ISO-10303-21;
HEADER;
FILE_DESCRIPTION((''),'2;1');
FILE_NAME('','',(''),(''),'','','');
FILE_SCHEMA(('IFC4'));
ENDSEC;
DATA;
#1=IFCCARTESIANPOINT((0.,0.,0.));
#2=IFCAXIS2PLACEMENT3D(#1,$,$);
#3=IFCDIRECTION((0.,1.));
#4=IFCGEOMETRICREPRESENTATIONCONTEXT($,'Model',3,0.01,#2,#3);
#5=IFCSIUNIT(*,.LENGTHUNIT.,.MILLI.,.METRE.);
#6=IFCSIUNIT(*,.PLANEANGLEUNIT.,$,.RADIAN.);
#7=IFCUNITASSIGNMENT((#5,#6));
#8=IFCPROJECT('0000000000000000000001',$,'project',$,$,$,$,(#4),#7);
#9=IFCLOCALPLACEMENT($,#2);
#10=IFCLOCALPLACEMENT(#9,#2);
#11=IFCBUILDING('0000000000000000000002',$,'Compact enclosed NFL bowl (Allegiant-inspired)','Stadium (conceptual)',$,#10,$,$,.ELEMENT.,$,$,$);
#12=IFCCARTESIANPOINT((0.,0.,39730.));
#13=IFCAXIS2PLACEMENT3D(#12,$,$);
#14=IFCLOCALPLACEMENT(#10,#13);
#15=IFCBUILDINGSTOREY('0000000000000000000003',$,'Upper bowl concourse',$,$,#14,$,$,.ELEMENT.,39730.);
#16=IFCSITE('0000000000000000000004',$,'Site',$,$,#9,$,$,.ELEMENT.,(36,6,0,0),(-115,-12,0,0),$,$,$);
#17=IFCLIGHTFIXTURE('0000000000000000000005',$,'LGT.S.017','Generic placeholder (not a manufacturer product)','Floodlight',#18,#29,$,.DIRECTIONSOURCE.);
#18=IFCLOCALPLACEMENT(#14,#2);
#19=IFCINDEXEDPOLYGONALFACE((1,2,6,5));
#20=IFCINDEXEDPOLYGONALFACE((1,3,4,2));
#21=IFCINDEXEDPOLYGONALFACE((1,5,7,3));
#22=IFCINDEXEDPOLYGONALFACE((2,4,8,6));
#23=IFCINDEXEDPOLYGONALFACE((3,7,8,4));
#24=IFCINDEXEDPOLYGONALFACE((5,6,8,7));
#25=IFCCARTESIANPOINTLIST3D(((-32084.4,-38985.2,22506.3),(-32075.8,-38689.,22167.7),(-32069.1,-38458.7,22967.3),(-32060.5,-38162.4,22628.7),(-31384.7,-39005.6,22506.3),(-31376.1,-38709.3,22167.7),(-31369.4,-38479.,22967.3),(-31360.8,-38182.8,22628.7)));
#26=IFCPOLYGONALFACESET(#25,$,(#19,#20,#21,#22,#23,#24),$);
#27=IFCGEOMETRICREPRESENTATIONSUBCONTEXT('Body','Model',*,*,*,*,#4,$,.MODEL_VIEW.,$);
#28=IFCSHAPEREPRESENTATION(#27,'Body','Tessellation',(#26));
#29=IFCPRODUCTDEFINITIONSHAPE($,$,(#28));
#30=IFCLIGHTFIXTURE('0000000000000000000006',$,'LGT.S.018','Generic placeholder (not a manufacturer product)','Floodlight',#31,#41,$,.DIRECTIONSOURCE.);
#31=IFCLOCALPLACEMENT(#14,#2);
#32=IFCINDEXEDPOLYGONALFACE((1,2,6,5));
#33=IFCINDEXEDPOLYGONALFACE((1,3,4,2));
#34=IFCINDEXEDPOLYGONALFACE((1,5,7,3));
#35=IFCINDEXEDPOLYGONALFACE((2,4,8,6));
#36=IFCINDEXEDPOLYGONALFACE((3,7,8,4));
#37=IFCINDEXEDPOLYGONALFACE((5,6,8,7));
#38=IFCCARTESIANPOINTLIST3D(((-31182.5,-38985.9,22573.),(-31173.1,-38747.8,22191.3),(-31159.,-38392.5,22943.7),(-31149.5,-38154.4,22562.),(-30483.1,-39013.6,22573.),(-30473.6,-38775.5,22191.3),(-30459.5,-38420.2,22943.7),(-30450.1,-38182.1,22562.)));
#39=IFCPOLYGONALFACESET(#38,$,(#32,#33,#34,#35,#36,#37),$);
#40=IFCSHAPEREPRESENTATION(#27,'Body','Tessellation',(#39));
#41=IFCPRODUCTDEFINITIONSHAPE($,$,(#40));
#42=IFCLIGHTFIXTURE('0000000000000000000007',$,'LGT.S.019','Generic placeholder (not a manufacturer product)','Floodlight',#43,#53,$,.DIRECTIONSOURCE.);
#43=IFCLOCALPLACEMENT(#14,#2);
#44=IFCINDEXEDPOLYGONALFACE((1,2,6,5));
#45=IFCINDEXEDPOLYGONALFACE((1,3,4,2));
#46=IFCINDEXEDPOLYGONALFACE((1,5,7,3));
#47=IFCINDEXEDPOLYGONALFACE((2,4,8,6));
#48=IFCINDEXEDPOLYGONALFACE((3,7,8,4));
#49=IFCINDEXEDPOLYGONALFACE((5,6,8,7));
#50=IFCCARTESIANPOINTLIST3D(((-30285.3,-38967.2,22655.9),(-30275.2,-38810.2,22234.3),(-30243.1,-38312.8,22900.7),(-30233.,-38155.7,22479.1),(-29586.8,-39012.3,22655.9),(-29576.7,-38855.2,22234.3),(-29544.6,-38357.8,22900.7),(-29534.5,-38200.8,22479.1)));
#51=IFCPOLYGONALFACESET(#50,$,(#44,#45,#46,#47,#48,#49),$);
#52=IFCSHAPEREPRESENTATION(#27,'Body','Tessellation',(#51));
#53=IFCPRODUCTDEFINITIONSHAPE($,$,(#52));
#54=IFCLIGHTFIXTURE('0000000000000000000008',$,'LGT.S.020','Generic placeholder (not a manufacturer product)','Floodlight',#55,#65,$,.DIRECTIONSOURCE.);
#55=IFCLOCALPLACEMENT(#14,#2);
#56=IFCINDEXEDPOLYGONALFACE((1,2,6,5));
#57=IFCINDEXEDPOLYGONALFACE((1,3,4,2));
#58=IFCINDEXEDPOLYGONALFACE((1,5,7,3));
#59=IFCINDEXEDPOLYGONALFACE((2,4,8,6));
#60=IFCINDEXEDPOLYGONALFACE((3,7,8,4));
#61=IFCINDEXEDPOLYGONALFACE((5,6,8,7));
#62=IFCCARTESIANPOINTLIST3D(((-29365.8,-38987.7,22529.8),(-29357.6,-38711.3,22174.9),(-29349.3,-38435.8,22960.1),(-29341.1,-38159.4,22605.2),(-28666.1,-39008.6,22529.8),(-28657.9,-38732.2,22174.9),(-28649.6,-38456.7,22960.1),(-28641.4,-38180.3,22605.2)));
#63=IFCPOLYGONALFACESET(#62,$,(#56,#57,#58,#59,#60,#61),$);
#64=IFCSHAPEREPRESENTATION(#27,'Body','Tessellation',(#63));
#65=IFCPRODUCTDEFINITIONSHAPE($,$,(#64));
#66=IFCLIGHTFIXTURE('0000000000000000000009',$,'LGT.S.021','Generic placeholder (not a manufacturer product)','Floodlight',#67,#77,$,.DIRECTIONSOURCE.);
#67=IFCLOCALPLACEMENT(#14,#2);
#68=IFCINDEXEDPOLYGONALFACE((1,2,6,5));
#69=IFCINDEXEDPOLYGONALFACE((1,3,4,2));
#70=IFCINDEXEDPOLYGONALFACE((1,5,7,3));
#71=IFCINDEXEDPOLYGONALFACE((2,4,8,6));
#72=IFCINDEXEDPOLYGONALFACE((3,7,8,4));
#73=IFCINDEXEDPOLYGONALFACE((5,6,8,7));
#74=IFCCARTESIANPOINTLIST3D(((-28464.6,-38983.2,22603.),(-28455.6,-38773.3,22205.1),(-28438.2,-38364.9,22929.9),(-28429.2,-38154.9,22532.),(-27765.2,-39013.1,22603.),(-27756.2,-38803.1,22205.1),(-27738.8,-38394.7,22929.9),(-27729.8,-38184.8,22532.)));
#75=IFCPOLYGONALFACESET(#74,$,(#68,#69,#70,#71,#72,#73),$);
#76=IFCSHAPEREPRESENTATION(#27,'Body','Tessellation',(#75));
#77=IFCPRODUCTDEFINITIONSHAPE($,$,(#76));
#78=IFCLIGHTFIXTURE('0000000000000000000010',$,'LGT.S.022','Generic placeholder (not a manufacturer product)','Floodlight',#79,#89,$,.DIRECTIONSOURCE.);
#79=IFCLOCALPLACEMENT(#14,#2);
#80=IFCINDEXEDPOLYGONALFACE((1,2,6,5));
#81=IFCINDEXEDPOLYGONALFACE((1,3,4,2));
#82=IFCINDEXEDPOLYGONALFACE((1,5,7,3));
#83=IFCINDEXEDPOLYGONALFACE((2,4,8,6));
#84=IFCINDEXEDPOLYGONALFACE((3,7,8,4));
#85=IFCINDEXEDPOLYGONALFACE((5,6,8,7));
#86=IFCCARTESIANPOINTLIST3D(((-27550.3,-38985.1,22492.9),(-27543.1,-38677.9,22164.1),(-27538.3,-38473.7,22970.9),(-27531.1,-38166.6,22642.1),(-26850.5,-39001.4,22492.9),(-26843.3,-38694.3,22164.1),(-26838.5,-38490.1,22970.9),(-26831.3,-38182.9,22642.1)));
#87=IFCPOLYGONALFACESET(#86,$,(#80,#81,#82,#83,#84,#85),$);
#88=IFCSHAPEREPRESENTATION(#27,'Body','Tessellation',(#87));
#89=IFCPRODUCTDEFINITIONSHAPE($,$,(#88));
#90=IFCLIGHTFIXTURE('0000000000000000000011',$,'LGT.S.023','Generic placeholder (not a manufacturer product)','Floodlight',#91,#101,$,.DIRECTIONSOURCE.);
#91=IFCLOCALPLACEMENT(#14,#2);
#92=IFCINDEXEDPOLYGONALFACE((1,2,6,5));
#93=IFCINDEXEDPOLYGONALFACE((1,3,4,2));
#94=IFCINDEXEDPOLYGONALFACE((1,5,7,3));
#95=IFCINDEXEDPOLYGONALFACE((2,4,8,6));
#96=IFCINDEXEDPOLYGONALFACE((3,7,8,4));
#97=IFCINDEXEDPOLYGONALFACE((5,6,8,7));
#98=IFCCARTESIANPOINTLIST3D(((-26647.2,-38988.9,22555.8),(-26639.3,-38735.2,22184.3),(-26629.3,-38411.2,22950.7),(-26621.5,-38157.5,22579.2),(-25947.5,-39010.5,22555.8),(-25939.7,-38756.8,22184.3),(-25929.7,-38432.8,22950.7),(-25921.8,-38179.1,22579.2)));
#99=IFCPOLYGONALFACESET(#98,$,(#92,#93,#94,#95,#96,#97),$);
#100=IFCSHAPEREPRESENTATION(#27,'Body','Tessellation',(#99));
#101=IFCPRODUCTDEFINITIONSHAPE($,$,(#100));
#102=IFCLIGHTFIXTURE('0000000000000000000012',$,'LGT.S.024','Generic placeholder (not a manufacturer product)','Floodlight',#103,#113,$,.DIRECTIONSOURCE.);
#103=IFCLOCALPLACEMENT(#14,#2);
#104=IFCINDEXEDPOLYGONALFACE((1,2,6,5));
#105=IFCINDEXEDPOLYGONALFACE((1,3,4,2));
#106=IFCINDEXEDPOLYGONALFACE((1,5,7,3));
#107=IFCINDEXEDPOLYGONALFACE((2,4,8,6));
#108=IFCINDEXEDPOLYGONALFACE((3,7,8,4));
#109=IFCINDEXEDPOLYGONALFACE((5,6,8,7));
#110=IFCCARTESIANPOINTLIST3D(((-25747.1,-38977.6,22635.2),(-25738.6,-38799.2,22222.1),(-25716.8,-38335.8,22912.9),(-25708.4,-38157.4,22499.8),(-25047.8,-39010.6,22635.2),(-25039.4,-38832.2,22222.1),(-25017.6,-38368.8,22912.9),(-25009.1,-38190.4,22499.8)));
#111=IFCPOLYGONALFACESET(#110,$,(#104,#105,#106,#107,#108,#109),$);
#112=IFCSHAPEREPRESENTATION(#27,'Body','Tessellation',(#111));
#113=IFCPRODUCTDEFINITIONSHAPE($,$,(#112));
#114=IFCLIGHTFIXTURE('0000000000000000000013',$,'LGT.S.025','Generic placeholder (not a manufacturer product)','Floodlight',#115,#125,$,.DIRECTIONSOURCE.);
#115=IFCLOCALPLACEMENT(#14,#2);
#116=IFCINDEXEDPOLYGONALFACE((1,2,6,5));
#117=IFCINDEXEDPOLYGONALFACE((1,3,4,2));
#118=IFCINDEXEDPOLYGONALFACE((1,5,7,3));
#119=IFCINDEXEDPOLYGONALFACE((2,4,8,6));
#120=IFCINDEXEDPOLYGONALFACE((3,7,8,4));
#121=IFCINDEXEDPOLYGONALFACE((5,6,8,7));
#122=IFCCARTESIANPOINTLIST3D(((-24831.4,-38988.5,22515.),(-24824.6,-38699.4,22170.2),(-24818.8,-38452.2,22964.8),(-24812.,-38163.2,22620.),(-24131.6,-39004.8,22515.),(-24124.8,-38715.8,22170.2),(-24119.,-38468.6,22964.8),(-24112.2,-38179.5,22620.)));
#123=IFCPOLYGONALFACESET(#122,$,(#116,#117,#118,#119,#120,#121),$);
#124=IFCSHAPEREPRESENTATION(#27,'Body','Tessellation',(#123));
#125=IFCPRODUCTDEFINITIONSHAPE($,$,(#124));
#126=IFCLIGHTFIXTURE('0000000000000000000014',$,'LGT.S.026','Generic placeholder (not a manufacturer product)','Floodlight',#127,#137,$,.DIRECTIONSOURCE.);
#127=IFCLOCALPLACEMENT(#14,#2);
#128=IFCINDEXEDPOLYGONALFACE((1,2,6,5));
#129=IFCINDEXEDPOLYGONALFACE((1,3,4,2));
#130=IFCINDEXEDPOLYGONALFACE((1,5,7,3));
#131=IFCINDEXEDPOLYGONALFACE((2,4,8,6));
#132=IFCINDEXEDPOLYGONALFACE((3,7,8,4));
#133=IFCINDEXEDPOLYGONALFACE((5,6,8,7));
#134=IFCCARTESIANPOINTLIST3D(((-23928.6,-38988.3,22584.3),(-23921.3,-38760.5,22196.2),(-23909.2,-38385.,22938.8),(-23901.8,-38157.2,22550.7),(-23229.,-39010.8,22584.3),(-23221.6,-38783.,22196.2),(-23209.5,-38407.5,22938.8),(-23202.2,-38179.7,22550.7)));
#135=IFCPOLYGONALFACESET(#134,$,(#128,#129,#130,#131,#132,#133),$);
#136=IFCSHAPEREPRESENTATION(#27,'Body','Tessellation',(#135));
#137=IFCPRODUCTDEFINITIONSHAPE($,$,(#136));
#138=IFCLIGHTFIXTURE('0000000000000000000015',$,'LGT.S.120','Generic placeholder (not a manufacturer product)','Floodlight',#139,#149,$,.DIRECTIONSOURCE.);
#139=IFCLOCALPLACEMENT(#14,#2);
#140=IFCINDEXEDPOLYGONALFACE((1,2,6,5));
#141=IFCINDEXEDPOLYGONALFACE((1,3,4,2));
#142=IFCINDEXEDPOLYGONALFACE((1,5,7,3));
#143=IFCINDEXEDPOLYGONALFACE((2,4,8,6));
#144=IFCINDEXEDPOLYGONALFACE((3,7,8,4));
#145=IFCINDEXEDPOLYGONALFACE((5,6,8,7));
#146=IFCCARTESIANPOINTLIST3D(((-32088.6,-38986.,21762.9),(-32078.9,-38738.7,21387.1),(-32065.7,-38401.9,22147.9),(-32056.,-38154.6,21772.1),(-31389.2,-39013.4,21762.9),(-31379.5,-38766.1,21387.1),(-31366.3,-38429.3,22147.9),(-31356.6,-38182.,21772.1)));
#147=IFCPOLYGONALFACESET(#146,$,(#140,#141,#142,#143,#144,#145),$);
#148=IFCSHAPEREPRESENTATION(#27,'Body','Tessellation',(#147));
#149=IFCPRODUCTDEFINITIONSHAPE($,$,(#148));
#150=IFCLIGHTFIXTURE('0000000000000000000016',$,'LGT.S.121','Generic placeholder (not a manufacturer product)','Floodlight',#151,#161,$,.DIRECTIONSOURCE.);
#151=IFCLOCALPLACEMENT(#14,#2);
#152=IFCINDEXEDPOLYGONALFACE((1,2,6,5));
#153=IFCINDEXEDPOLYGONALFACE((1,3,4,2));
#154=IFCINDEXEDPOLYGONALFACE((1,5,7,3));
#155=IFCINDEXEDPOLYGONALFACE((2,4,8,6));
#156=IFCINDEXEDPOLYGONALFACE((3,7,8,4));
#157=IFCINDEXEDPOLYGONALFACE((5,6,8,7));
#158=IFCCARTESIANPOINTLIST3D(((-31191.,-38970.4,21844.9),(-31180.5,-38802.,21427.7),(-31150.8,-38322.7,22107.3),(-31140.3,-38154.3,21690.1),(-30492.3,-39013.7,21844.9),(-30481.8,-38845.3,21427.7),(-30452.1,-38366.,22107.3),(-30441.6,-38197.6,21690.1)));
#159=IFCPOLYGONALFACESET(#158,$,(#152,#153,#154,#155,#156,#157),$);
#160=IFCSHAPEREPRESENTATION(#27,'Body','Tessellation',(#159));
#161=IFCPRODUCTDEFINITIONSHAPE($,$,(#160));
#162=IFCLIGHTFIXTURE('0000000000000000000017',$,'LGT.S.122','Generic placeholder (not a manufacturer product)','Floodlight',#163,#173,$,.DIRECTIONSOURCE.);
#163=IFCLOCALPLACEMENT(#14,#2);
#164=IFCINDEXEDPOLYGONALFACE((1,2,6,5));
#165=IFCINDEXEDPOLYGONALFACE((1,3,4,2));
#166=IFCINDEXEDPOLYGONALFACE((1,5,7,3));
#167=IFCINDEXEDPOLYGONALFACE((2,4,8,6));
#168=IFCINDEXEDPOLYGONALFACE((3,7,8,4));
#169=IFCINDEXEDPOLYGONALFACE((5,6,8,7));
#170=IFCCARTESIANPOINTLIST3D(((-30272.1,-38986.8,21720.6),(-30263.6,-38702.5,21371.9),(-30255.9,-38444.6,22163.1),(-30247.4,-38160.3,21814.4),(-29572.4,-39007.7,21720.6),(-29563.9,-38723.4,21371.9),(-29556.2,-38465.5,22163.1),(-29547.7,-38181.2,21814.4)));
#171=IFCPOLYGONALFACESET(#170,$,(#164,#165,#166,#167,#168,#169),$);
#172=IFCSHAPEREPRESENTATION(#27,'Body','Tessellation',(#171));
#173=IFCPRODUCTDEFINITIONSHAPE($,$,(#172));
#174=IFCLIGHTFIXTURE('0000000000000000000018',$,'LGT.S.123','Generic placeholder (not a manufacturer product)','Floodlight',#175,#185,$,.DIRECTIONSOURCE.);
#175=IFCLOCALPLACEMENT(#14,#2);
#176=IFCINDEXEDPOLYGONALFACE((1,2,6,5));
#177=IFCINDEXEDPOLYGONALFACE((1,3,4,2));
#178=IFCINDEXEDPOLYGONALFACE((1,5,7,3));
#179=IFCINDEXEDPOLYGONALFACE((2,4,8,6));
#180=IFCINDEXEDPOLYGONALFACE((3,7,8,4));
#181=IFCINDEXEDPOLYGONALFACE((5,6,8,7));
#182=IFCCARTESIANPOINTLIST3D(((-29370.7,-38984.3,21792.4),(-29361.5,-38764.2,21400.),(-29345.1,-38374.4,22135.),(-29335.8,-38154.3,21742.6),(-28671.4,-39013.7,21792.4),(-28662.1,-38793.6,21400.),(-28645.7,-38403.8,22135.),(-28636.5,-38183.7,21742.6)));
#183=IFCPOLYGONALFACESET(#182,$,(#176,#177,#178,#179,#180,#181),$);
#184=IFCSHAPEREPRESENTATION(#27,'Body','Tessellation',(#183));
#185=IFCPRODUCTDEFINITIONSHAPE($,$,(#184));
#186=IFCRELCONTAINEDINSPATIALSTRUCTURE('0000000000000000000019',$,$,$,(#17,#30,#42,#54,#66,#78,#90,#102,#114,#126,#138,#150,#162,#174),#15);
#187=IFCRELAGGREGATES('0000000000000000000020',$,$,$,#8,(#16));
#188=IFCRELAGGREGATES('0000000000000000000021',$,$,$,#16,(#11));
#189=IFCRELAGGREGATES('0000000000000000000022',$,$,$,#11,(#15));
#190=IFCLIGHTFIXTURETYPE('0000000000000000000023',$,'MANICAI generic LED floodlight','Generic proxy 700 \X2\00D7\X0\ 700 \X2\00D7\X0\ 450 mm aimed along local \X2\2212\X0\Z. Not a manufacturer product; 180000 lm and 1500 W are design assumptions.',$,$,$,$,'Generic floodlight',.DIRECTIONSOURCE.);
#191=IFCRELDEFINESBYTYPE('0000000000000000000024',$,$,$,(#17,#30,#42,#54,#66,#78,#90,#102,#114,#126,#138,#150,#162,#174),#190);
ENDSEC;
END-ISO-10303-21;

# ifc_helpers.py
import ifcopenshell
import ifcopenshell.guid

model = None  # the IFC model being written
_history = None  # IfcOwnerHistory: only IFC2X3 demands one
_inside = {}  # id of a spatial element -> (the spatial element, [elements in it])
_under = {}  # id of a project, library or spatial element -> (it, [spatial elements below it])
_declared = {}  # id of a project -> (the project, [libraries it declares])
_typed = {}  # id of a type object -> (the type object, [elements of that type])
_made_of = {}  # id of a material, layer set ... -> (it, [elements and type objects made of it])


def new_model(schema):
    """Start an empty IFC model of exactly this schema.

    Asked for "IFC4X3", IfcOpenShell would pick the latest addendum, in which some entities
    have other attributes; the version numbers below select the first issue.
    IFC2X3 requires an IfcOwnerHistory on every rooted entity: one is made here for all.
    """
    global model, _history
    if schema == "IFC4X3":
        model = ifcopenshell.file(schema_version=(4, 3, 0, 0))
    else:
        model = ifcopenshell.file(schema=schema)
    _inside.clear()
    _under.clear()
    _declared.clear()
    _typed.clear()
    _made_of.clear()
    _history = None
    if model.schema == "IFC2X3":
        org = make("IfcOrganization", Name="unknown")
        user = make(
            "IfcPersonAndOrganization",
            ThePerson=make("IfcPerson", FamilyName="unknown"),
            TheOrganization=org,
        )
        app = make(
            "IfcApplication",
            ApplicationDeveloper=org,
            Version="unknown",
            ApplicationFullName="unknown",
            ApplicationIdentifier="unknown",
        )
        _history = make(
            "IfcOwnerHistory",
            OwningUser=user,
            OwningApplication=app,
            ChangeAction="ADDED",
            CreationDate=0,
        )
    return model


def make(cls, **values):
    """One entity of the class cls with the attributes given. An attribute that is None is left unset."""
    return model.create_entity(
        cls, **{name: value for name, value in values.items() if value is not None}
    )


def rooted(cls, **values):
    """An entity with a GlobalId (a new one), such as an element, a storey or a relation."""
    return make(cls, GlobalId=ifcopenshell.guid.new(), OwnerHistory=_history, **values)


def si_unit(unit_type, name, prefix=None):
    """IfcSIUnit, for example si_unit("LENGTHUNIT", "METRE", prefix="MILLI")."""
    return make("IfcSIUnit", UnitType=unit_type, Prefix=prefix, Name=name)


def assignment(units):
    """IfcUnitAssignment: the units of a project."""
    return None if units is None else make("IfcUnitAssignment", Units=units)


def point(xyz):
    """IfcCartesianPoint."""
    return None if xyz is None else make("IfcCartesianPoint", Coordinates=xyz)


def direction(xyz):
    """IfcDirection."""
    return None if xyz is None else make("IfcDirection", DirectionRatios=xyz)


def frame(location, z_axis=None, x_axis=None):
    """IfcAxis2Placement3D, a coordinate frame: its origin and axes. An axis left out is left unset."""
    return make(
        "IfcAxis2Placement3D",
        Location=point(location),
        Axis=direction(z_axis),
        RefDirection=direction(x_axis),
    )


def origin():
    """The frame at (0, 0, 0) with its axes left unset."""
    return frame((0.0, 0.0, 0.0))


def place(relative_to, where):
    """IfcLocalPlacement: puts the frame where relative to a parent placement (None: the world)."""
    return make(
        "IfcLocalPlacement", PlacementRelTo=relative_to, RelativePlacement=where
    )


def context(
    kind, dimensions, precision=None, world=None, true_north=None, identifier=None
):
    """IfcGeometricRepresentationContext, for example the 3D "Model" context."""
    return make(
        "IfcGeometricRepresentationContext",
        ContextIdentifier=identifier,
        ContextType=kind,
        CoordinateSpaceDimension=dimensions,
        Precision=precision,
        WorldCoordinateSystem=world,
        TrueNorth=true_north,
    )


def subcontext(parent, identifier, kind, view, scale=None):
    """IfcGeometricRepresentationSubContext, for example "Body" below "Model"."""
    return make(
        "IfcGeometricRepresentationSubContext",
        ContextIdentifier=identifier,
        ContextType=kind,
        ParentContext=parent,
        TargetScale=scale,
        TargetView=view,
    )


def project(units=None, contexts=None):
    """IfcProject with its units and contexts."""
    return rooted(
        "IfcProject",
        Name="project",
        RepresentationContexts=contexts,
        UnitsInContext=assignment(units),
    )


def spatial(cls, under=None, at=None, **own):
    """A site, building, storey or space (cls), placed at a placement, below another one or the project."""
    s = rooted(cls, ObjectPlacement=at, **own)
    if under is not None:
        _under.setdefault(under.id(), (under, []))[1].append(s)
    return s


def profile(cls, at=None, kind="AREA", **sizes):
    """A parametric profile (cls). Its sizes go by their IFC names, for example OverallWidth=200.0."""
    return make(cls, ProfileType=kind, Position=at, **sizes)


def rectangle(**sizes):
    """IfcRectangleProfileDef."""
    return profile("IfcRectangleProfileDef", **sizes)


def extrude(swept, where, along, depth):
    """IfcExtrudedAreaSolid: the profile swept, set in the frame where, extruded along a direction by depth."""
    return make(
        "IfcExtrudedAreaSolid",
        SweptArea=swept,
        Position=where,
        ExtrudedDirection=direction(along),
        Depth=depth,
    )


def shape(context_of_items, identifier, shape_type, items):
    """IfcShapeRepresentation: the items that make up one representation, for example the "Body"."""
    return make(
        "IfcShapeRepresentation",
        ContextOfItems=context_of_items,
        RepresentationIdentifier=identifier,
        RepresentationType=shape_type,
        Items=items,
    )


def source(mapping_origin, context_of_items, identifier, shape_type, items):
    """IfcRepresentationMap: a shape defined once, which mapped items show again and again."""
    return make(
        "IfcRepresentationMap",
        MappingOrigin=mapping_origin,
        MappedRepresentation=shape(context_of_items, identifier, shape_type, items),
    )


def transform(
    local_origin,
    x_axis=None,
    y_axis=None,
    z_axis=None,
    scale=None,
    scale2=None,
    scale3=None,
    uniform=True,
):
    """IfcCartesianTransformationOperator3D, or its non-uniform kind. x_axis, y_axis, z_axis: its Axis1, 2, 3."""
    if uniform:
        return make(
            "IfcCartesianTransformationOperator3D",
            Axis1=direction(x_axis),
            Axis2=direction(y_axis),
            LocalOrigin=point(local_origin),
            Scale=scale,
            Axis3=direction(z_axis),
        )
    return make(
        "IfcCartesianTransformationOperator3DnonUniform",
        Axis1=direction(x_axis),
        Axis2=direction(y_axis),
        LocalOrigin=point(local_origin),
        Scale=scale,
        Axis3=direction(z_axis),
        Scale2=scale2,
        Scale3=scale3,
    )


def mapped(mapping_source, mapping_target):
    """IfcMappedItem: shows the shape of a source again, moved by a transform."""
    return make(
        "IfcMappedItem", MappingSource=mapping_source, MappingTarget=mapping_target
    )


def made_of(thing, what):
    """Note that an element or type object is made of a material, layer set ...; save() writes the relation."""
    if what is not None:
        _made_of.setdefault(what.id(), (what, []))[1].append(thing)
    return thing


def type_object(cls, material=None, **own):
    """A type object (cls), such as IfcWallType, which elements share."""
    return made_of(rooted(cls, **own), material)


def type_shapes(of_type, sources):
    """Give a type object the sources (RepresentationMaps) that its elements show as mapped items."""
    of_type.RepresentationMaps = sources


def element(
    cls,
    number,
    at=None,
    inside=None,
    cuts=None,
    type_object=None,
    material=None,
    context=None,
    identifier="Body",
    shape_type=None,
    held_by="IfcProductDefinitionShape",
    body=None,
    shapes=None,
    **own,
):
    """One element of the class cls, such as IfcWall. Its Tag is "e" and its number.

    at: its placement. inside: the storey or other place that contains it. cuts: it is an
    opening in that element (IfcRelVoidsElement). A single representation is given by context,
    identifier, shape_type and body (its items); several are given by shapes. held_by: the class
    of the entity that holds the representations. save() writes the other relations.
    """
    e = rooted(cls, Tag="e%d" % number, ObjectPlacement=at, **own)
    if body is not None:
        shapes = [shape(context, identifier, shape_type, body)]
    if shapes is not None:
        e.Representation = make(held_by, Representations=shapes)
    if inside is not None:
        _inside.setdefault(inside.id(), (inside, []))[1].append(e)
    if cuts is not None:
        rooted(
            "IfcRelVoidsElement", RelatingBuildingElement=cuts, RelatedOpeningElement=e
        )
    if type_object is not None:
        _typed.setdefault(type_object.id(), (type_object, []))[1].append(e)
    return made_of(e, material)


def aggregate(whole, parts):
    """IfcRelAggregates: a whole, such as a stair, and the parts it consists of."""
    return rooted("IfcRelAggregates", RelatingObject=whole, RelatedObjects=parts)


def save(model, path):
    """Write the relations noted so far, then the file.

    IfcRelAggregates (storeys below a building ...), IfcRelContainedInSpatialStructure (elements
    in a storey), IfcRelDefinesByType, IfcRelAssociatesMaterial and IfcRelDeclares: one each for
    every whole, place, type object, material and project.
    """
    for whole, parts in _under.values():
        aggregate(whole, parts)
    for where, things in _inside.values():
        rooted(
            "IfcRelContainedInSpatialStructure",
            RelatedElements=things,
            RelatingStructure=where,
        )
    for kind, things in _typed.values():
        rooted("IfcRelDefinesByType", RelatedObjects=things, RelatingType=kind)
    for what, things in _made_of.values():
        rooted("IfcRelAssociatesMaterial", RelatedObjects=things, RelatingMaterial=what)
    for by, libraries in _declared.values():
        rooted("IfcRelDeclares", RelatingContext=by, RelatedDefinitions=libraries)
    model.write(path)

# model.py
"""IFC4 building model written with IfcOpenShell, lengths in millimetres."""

from ifc_helpers import new_model, si_unit, direction, frame, origin, place, context, subcontext, project, spatial, rectangle, extrude, source, transform, mapped, type_object, type_shapes, element, save


model = new_model("IFC4")

# Units and contexts
model_context = context("Model", 3, precision=0.01, world=origin(), true_north=direction((0.0, 1.0)))
body_context = subcontext(model_context, "Body", "Model", "MODEL_VIEW")
ifc_project = project(units=[si_unit("LENGTHUNIT", "METRE", prefix="MILLI"), si_unit("PLANEANGLEUNIT", "RADIAN")], contexts=[model_context])

# Site, building, storey
site_placement = place(None, origin())
site = spatial("IfcSite", under=ifc_project, at=site_placement, Name="Site", CompositionType="ELEMENT", RefLatitude=(36, 6, 0, 0), RefLongitude=(-115, -12, 0, 0))
building_placement = place(site_placement, origin())
building = spatial("IfcBuilding", under=site, at=building_placement, Name="Compact enclosed NFL bowl (Allegiant-inspired)", Description="Stadium (conceptual)", CompositionType="ELEMENT")
storey_placement = place(building_placement, frame((0.0, 0.0, 39730.0)))
storey = spatial("IfcBuildingStorey", under=building, at=storey_placement, Name="Upper bowl concourse", CompositionType="ELEMENT", Elevation=39730.0)

# Light fixtures
light_fixture_type = type_object("IfcLightFixtureType", Name="MANICAI generic LED floodlight", Description="Generic proxy 700 × 700 × 450 mm aimed along local −Z. Not a manufacturer product; 180000 lm and 1500 W are design assumptions.", ElementType="Generic floodlight", PredefinedType="DIRECTIONSOURCE")
shared_shape = source(origin(), body_context, "Body", "SweptSolid", [
    extrude(rectangle(XDim=700.0, YDim=700.0), frame((0.0, 0.0, -225.0)), (0.0, 0.0, 1.0), 450.0),
])
type_shapes(light_fixture_type, [shared_shape])
for number, where, z_axis, x_axis, name in (
    (1, (-31722.6, -38584.0, 22567.5), (-0.019159, -0.658318, 0.752496), (0.999577, -0.029091, 0.0), "LGT.S.017"),
    (2, (-30816.3, -38584.0, 22567.5), (-0.020982, -0.529075, 0.848316), (0.999215, -0.039626, 0.0), "LGT.S.018"),
    (3, (-29909.9, -38584.0, 22567.5), (-0.02249, -0.348985, 0.936858), (0.99793, -0.06431, 0.0), "LGT.S.019"),
    (4, (-29003.6, -38584.0, 22567.5), (-0.018362, -0.614392, 0.788787), (0.999554, -0.029872, 0.0), "LGT.S.020"),
    (5, (-28097.2, -38584.0, 22567.5), (-0.01994, -0.466638, 0.884224), (0.999088, -0.042692, 0.0), "LGT.S.021"),
    (6, (-27190.8, -38584.0, 22567.5), (-0.015946, -0.682546, 0.730668), (0.999727, -0.023356, 0.0), "LGT.S.022"),
    (7, (-26284.5, -38584.0, 22567.5), (-0.017418, -0.5639, 0.825659), (0.999523, -0.030874, 0.0), "LGT.S.023"),
    (8, (-25378.1, -38584.0, 22567.5), (-0.018696, -0.396352, 0.917908), (0.998889, -0.047119, 0.0), "LGT.S.024"),
    (9, (-24471.8, -38584.0, 22567.5), (-0.015051, -0.642311, 0.766296), (0.999726, -0.023426, 0.0), "LGT.S.025"),
    (10, (-23565.4, -38584.0, 22567.5), (-0.016309, -0.506181, 0.862273), (0.999481, -0.032202, 0.0), "LGT.S.026"),
    (11, (-31722.6, -38584.0, 21767.5), (-0.02154, -0.549597, 0.835152), (0.999233, -0.039163, 0.0), "LGT.S.120"),
    (12, (-30816.3, -38584.0, 21767.5), (-0.023227, -0.374199, 0.927058), (0.998079, -0.061953, 0.0), "LGT.S.121"),
    (13, (-29909.9, -38584.0, 21767.5), (-0.018844, -0.631801, 0.774902), (0.999556, -0.029813, 0.0), "LGT.S.122"),
    (14, (-29003.6, -38584.0, 21767.5), (-0.020562, -0.489093, 0.871989), (0.999117, -0.042005, 0.0), "LGT.S.123"),
):
    element("IfcLightFixture", number, at=place(storey_placement, frame(where, z_axis=z_axis, x_axis=x_axis)), inside=storey, type_object=light_fixture_type, Name=name, Description="Generic placeholder (not a manufacturer product)", ObjectType="Floodlight", PredefinedType="DIRECTIONSOURCE", context=body_context, shape_type="MappedRepresentation", body=[
        mapped(shared_shape, transform((0.0, 0.0, 0.0))),
    ])

save(model, "model.ifc")
